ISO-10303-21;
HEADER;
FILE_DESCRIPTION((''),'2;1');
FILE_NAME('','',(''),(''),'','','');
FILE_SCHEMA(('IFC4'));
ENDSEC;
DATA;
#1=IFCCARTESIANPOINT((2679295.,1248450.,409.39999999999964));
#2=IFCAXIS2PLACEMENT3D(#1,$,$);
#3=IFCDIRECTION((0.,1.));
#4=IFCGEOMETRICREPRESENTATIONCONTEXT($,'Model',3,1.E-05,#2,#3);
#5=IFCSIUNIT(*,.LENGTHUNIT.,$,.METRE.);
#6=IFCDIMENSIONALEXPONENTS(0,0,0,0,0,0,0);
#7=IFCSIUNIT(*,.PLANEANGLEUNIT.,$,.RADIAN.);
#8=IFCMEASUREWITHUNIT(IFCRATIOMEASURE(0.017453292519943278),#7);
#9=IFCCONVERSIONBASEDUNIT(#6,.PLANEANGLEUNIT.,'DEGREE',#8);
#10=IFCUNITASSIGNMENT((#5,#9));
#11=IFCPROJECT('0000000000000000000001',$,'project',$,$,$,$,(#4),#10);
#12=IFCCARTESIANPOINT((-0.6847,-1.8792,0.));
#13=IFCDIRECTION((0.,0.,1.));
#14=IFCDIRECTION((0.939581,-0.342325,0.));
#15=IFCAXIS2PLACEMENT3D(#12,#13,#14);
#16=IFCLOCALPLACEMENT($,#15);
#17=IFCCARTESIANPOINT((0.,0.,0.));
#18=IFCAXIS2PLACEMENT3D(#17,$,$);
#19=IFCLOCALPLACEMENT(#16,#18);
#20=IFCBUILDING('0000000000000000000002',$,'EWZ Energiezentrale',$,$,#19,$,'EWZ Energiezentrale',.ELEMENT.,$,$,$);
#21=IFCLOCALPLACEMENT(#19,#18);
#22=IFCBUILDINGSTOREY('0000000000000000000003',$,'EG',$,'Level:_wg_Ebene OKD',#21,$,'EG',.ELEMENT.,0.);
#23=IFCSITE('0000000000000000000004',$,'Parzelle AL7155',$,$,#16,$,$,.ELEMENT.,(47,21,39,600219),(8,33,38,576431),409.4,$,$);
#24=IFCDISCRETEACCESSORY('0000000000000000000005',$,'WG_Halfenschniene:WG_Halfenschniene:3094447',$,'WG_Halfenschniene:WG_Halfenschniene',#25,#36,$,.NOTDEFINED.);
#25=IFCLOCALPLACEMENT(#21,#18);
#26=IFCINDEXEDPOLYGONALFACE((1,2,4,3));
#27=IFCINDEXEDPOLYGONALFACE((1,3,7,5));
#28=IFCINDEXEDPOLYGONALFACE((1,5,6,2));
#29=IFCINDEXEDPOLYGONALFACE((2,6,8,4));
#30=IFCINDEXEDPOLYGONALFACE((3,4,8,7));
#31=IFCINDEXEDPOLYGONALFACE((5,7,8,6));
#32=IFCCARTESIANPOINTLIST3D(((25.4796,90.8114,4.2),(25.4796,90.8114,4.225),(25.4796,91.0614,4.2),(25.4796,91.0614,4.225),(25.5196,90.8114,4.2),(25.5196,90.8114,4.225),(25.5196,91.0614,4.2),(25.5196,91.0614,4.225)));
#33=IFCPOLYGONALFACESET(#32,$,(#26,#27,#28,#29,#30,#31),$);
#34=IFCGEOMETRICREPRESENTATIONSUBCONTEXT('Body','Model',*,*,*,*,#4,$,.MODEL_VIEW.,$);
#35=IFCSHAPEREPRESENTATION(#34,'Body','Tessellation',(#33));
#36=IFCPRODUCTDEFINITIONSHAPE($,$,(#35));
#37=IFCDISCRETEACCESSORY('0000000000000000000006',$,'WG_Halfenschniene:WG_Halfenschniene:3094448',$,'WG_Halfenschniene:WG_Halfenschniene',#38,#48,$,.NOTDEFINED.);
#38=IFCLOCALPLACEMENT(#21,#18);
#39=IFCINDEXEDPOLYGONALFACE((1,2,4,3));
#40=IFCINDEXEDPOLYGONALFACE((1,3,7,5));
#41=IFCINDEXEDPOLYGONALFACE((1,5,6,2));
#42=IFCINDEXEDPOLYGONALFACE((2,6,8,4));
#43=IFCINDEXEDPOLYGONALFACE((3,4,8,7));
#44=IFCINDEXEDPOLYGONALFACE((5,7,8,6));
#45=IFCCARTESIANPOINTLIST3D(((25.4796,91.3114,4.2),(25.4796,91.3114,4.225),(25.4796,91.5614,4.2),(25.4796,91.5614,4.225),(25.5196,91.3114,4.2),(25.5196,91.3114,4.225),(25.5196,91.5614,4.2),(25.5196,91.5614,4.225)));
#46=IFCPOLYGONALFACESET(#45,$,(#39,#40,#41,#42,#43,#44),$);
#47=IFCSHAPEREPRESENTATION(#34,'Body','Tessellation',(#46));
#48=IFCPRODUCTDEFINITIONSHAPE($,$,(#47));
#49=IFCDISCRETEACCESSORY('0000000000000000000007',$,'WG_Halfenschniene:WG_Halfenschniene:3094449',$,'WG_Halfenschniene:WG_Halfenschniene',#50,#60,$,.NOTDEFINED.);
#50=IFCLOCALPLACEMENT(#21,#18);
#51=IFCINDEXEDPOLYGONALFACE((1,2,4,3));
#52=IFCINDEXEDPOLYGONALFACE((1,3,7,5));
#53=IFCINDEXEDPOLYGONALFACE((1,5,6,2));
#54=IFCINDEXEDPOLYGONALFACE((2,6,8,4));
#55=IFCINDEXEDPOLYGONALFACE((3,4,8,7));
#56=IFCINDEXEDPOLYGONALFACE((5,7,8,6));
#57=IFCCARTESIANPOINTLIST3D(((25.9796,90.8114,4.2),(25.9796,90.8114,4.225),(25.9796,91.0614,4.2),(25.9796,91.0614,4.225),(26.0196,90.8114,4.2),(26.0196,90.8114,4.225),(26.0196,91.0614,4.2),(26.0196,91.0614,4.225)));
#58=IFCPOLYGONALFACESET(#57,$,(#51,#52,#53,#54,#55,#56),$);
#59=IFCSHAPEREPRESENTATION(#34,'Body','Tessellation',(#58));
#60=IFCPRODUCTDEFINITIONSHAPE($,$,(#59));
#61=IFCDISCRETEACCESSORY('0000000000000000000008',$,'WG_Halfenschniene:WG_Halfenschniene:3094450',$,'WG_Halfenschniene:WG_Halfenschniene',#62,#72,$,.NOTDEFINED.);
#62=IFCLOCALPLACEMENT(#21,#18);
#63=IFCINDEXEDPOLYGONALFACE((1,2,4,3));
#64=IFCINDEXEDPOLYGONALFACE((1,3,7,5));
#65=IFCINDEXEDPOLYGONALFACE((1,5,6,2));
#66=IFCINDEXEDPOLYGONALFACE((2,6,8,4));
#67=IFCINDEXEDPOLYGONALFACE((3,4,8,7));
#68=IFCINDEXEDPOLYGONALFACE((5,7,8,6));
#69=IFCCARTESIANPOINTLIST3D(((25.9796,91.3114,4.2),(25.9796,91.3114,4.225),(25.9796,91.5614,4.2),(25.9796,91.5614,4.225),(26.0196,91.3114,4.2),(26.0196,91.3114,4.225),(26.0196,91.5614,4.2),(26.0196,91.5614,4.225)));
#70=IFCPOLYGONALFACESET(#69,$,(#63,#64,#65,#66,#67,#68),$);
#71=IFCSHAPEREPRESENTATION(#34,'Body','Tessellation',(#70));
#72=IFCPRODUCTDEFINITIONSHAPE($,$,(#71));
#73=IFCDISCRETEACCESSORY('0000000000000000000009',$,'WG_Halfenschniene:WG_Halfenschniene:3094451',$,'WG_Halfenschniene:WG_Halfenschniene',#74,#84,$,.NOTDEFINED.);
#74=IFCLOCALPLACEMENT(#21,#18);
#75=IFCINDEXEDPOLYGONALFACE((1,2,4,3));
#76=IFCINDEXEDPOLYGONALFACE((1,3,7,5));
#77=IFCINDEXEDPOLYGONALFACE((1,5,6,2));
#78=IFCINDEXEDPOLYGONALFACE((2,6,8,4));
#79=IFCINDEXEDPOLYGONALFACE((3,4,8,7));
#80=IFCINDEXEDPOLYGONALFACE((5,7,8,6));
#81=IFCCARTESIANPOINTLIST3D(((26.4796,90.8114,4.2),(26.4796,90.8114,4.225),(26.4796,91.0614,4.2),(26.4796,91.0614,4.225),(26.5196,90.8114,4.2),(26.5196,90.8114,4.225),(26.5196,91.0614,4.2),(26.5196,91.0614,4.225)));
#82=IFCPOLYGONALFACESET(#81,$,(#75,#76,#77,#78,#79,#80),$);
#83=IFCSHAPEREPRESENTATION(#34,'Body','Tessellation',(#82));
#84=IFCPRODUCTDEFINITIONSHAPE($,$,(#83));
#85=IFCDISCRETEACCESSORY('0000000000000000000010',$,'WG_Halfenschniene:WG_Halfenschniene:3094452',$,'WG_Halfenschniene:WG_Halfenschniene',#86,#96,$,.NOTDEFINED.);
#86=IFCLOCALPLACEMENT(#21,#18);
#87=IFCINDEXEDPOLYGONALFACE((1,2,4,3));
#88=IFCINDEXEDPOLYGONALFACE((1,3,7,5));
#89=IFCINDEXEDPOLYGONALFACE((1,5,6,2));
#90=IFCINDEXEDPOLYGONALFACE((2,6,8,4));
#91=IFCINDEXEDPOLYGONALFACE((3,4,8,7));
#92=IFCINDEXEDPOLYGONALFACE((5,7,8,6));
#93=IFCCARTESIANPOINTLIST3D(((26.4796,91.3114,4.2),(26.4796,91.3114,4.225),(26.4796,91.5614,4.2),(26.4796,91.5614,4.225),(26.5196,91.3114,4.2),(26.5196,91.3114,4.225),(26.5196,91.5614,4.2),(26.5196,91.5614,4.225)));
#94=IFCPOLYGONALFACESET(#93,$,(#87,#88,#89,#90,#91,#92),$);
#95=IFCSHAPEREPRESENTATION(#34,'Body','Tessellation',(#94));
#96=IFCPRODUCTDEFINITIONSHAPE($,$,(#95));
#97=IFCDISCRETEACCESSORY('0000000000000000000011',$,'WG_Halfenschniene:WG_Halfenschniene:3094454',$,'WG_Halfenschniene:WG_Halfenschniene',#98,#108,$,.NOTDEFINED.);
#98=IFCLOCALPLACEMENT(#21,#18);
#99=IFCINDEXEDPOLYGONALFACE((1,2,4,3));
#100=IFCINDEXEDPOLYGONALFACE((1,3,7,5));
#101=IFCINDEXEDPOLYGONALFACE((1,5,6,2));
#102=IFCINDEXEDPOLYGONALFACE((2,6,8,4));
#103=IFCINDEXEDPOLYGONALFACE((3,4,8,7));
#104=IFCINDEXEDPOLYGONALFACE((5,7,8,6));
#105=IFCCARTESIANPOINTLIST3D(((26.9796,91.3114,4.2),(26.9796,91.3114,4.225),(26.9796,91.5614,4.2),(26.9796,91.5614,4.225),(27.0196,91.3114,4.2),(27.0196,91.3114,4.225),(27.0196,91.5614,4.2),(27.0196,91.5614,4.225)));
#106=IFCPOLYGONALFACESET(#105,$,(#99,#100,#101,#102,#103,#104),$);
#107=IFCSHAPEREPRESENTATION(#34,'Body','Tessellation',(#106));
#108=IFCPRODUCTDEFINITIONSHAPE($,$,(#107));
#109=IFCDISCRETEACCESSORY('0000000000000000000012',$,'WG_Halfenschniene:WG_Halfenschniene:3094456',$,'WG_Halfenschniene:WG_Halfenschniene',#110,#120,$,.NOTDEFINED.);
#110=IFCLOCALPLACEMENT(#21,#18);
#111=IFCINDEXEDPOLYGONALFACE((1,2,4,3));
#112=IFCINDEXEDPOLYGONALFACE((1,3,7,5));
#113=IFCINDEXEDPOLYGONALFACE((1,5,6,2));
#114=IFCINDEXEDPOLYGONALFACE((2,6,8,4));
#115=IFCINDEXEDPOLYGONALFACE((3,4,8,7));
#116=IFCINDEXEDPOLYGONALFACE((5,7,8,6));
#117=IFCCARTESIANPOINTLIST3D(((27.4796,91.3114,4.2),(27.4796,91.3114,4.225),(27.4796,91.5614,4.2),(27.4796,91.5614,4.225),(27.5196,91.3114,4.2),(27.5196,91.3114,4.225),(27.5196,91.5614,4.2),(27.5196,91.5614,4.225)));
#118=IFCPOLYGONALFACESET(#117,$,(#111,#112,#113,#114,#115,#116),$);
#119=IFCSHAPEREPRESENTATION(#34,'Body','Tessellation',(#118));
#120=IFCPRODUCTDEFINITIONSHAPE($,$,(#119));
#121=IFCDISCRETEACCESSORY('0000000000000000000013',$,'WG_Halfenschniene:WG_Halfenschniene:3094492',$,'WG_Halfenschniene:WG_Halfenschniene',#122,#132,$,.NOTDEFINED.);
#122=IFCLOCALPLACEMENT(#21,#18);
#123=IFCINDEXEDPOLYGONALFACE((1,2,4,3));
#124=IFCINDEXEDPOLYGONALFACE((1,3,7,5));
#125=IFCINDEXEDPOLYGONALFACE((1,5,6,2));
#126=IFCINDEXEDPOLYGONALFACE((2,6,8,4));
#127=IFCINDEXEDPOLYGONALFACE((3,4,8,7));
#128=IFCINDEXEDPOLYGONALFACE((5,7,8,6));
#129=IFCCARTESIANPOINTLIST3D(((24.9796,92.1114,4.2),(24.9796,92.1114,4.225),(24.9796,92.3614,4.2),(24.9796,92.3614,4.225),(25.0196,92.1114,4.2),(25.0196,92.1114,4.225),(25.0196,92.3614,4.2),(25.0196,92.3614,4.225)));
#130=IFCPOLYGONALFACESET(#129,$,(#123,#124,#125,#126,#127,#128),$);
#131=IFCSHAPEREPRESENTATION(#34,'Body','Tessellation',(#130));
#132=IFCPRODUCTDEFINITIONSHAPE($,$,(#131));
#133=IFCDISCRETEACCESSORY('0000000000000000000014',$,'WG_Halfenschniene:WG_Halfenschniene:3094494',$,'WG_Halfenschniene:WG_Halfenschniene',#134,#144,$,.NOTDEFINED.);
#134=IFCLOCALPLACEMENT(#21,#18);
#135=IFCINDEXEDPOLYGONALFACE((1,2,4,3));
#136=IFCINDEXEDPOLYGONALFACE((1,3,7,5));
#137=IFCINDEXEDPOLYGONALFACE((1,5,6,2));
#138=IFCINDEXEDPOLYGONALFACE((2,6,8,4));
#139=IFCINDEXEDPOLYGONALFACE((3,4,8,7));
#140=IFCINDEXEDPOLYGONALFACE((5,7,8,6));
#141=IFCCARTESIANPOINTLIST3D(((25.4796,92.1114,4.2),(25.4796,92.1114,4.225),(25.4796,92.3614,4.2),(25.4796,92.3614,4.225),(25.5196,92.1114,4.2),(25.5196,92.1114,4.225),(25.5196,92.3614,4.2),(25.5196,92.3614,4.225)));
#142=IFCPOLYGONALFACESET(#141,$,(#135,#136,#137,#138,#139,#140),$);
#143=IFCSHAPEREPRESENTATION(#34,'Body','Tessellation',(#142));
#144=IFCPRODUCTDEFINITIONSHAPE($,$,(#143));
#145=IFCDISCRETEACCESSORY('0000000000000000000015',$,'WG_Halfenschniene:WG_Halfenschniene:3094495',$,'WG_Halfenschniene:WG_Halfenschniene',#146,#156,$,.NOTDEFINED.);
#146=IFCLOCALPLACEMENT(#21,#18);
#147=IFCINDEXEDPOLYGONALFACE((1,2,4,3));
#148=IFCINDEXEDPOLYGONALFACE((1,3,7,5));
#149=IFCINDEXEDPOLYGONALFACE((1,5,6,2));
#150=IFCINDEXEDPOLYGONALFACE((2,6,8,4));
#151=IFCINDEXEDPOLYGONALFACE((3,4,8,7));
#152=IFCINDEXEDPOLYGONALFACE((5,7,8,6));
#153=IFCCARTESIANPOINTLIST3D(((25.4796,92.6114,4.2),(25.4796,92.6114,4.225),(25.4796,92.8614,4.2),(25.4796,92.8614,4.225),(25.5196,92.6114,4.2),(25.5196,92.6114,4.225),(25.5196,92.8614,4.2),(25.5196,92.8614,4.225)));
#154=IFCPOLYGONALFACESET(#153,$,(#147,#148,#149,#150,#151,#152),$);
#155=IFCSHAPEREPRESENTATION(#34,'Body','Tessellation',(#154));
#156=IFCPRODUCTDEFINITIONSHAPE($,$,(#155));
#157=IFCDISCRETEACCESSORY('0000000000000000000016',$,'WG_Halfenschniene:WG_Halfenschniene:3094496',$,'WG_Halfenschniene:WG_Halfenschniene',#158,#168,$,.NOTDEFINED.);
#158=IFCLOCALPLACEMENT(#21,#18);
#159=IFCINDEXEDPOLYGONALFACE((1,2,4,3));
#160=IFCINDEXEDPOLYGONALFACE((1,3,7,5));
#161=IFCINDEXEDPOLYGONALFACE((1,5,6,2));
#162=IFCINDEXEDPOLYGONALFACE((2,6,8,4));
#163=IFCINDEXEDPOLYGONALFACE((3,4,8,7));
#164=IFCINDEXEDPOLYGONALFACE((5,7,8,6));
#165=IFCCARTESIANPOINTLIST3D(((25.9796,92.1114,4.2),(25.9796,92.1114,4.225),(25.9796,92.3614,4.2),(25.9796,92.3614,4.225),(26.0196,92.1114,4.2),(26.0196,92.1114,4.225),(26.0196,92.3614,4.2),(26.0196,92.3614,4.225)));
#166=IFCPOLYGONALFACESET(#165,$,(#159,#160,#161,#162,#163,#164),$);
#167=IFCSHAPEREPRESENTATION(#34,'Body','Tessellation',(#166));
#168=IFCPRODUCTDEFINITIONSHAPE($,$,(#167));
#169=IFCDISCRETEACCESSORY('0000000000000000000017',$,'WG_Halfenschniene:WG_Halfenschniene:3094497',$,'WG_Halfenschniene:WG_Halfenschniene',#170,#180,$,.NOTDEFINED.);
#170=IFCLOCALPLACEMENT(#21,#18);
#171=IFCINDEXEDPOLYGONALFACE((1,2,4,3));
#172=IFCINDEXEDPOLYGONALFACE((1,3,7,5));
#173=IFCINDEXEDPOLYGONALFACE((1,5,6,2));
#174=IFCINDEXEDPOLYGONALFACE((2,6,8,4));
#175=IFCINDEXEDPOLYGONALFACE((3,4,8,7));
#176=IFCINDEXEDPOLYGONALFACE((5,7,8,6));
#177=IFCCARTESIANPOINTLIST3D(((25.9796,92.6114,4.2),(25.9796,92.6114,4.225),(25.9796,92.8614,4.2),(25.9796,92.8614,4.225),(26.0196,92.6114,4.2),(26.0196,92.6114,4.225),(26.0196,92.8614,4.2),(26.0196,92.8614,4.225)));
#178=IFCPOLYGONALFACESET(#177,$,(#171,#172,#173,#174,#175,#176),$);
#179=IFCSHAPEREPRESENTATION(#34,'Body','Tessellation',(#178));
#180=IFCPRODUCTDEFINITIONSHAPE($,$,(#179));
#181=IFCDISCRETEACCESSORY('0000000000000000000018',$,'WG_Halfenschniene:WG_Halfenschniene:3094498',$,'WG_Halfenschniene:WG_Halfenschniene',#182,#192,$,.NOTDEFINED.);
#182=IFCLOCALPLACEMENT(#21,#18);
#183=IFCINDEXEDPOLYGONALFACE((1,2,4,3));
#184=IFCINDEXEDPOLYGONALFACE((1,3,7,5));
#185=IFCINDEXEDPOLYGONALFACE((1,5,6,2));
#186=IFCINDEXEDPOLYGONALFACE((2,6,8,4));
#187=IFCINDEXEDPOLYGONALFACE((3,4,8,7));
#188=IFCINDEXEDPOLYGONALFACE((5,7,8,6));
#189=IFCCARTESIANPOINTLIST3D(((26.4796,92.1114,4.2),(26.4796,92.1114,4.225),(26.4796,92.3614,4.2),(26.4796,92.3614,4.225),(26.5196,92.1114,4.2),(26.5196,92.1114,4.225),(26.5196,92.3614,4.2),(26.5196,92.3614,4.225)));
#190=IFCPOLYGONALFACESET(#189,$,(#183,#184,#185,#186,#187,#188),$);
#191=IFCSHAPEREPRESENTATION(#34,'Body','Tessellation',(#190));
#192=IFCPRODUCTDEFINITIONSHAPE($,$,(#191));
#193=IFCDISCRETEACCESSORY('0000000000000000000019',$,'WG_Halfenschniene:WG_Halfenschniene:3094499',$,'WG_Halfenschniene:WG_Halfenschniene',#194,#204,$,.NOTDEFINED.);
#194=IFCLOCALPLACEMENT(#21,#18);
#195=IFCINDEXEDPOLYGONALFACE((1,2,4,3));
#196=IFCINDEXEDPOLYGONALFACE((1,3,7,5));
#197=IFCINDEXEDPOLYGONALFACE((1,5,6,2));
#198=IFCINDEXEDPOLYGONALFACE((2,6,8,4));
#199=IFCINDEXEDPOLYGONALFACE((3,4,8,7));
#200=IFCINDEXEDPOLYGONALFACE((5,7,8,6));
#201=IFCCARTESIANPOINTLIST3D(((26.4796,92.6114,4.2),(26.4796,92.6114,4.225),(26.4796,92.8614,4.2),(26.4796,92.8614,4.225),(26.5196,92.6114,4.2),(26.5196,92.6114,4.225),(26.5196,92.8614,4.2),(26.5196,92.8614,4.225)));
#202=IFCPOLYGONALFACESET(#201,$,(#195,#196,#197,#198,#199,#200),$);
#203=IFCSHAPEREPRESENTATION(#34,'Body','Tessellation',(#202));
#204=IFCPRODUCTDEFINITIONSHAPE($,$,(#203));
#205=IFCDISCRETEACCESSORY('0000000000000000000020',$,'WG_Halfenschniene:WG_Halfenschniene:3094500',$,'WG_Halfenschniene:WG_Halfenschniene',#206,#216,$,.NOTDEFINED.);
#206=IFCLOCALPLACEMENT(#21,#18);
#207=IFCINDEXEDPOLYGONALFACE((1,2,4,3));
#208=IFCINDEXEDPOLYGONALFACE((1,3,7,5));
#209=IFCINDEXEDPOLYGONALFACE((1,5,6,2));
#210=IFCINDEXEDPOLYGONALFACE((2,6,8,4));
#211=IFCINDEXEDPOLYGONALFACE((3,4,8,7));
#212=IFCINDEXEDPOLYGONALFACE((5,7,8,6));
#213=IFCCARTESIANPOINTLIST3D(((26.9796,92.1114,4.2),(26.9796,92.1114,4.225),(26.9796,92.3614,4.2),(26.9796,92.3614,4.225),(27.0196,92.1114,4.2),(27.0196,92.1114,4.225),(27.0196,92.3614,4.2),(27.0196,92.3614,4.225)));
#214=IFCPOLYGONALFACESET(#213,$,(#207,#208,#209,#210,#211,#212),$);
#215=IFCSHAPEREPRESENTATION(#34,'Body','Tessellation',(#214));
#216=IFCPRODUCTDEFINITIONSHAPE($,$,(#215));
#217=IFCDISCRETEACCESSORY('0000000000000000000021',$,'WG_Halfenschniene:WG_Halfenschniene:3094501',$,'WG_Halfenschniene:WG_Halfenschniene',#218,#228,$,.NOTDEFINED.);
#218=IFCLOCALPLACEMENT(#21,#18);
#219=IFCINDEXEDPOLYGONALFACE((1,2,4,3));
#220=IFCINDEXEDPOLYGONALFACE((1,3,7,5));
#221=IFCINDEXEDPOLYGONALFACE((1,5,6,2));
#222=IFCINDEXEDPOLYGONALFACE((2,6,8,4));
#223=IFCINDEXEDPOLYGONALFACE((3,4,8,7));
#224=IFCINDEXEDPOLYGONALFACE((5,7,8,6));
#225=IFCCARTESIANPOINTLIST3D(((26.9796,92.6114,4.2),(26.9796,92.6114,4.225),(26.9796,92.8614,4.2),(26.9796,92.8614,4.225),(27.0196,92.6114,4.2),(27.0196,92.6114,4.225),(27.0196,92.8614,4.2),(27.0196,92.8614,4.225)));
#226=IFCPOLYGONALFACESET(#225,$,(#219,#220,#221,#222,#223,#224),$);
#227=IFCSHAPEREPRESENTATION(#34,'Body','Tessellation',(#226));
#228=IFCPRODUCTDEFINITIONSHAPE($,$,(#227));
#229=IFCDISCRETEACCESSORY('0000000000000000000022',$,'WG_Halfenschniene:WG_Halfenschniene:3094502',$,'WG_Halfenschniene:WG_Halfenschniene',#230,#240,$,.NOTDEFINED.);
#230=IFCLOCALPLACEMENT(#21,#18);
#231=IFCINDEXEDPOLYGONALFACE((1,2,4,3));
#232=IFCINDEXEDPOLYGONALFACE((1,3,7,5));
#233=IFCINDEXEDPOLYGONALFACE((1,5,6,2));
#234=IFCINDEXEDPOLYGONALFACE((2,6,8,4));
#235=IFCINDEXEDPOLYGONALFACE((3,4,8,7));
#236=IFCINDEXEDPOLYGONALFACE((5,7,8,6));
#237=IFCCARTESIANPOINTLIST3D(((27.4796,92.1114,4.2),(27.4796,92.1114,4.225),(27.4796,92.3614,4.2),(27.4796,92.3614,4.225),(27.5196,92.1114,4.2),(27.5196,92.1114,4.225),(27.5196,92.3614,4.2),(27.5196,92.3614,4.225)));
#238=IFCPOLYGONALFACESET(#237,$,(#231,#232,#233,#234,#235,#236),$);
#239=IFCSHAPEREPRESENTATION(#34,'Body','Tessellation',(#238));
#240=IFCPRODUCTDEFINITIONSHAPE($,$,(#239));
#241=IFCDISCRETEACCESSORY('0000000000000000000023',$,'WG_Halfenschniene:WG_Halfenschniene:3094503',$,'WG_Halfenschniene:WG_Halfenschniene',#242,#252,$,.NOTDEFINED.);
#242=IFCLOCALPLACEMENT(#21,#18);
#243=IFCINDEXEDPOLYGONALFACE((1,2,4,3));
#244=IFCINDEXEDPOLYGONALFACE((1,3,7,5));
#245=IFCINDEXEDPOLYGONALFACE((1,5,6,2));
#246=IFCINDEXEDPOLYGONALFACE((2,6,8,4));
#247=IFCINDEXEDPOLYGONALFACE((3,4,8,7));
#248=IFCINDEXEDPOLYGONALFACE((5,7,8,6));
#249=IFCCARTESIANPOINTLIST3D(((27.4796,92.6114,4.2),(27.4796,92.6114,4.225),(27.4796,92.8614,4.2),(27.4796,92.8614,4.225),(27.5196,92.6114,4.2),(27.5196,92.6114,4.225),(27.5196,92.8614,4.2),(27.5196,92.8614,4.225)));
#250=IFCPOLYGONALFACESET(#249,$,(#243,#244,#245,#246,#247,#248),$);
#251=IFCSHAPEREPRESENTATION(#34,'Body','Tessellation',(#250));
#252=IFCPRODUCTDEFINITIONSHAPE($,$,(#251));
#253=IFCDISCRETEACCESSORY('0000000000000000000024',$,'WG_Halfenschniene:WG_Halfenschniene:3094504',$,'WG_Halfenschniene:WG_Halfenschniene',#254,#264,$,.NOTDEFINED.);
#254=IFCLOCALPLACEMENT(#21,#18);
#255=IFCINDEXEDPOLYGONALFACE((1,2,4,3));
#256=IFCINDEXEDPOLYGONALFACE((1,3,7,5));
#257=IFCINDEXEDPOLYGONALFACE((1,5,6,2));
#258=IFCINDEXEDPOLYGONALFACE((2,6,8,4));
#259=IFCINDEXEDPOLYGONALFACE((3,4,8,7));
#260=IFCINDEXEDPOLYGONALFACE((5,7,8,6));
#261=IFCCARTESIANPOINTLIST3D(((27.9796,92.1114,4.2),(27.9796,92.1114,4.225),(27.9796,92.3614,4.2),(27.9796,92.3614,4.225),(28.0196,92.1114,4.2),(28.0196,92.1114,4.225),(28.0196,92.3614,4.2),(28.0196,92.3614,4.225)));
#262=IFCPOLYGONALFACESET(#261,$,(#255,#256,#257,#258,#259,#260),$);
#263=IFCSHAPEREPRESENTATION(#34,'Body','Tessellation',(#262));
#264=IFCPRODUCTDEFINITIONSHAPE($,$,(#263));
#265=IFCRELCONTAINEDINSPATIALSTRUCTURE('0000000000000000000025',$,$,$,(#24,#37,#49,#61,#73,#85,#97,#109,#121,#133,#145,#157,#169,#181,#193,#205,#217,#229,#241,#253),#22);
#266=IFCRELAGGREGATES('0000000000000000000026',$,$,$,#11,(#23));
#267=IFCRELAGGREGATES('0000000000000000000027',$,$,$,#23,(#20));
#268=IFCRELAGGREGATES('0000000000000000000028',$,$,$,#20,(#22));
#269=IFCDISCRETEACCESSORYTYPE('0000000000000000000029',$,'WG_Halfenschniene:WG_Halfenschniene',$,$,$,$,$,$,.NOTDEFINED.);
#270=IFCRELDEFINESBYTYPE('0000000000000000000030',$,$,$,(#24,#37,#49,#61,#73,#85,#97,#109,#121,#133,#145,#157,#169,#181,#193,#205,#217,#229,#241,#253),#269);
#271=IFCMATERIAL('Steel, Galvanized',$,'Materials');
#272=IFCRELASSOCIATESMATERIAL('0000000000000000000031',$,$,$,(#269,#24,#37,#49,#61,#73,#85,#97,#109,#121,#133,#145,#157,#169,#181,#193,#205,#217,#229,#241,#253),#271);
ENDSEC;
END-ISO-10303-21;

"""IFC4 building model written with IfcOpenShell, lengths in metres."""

from ifc_helpers import new_model, entity, si_unit, converted_unit, direction, frame, origin, place, context, subcontext, project, spatial, indexed_curve, outline, extrude, source, transform, mapped, material, type_object, element, save


model = new_model("IFC4")

# Units and contexts
model_context = context("Model", 3, precision=1e-05, world=frame((2679295.0, 1248450.0, 409.39999999999964)), true_north=direction((0.0, 1.0)))
body_context = subcontext(model_context, "Body", "Model", "MODEL_VIEW")
ifc_project = project(units=[si_unit("LENGTHUNIT", "METRE"), converted_unit("PLANEANGLEUNIT", "DEGREE", entity("IfcRatioMeasure", 0.017453292519943278), si_unit("PLANEANGLEUNIT", "RADIAN"), dimensions=[0, 0, 0, 0, 0, 0, 0])], contexts=[model_context])

# Site, building, storey
site_placement = place(None, frame((-0.6847, -1.8792, 0.0), z_axis=(0.0, 0.0, 1.0), x_axis=(0.939581, -0.342325, 0.0)))
site = spatial("IfcSite", under=ifc_project, at=site_placement, Name="Parzelle AL7155", CompositionType="ELEMENT", RefLatitude=(47, 21, 39, 600219), RefLongitude=(8, 33, 38, 576431), RefElevation=409.4)
building_placement = place(site_placement, origin())
building = spatial("IfcBuilding", under=site, at=building_placement, Name="EWZ Energiezentrale", LongName="EWZ Energiezentrale", CompositionType="ELEMENT")
storey_placement = place(building_placement, origin())
storey = spatial("IfcBuildingStorey", under=building, at=storey_placement, Name="EG", ObjectType="Level:_wg_Ebene OKD", LongName="EG", CompositionType="ELEMENT", Elevation=0.0)

# Discrete accessories
ifc_material = material(Name="Steel, Galvanized", Category="Materials")
discrete_accessory_type = type_object("IfcDiscreteAccessoryType", Name="WG_Halfenschniene:WG_Halfenschniene", PredefinedType="NOTDEFINED", material=ifc_material)
shared_shape = source(origin(), body_context, "Body", "SweptSolid", [
    extrude(outline(indexed_curve([(-0.125, -0.02), (0.125, -0.02), (0.125, 0.02), (-0.125, 0.02), (-0.125, -0.02)], self_intersect=False)), frame((0.125, 0.0, -0.0125)), (0.0, 0.0, 1.0), 0.025),
])
for number, where, z_axis, x_axis, name in (
    (1, (25.4996, 90.8114, 4.2125), (0.0, 0.0, -1.0), (0.0, 1.0, 0.0), "WG_Halfenschniene:WG_Halfenschniene:3094447"),
    (2, (25.4996, 91.3114, 4.2125), (0.0, 0.0, -1.0), (0.0, 1.0, 0.0), "WG_Halfenschniene:WG_Halfenschniene:3094448"),
    (3, (25.9996, 90.8114, 4.2125), (0.0, 0.0, -1.0), (0.0, 1.0, 0.0), "WG_Halfenschniene:WG_Halfenschniene:3094449"),
    (4, (25.9996, 91.3114, 4.2125), (0.0, 0.0, -1.0), (0.0, 1.0, 0.0), "WG_Halfenschniene:WG_Halfenschniene:3094450"),
    (5, (26.4996, 90.8114, 4.2125), (0.0, 0.0, -1.0), (0.0, 1.0, 0.0), "WG_Halfenschniene:WG_Halfenschniene:3094451"),
    (6, (26.4996, 91.3114, 4.2125), (0.0, 0.0, -1.0), (0.0, 1.0, 0.0), "WG_Halfenschniene:WG_Halfenschniene:3094452"),
    (7, (26.9996, 91.3114, 4.2125), (0.0, 0.0, -1.0), (0.0, 1.0, 0.0), "WG_Halfenschniene:WG_Halfenschniene:3094454"),
    (8, (27.4996, 91.3114, 4.2125), (0.0, 0.0, -1.0), (0.0, 1.0, 0.0), "WG_Halfenschniene:WG_Halfenschniene:3094456"),
    (9, (24.9996, 92.1114, 4.2125), (0.0, 0.0, -1.0), (0.0, 1.0, 0.0), "WG_Halfenschniene:WG_Halfenschniene:3094492"),
    (10, (25.4996, 92.1114, 4.2125), (0.0, 0.0, -1.0), (0.0, 1.0, 0.0), "WG_Halfenschniene:WG_Halfenschniene:3094494"),
    (11, (25.4996, 92.6114, 4.2125), (0.0, 0.0, -1.0), (0.0, 1.0, 0.0), "WG_Halfenschniene:WG_Halfenschniene:3094495"),
    (12, (25.9996, 92.1114, 4.2125), (0.0, 0.0, -1.0), (0.0, 1.0, 0.0), "WG_Halfenschniene:WG_Halfenschniene:3094496"),
    (13, (25.9996, 92.6114, 4.2125), (0.0, 0.0, -1.0), (0.0, 1.0, 0.0), "WG_Halfenschniene:WG_Halfenschniene:3094497"),
    (14, (26.4996, 92.1114, 4.2125), (0.0, 0.0, -1.0), (0.0, 1.0, 0.0), "WG_Halfenschniene:WG_Halfenschniene:3094498"),
    (15, (26.4996, 92.6114, 4.2125), (0.0, 0.0, -1.0), (0.0, 1.0, 0.0), "WG_Halfenschniene:WG_Halfenschniene:3094499"),
    (16, (26.9996, 92.1114, 4.2125), (0.0, 0.0, -1.0), (0.0, 1.0, 0.0), "WG_Halfenschniene:WG_Halfenschniene:3094500"),
    (17, (26.9996, 92.6114, 4.2125), (0.0, 0.0, -1.0), (0.0, 1.0, 0.0), "WG_Halfenschniene:WG_Halfenschniene:3094501"),
    (18, (27.4996, 92.1114, 4.2125), (0.0, 0.0, -1.0), (0.0, 1.0, 0.0), "WG_Halfenschniene:WG_Halfenschniene:3094502"),
    (19, (27.4996, 92.6114, 4.2125), (0.0, 0.0, -1.0), (0.0, 1.0, 0.0), "WG_Halfenschniene:WG_Halfenschniene:3094503"),
    (20, (27.9996, 92.1114, 4.2125), (0.0, 0.0, -1.0), (0.0, 1.0, 0.0), "WG_Halfenschniene:WG_Halfenschniene:3094504"),
):
    element("IfcDiscreteAccessory", number, at=place(storey_placement, frame(where, z_axis=z_axis, x_axis=x_axis)), inside=storey, type_object=discrete_accessory_type, material=ifc_material, Name=name, ObjectType="WG_Halfenschniene:WG_Halfenschniene", PredefinedType="NOTDEFINED", context=body_context, shape_type="MappedRepresentation", body=[
        mapped(shared_shape, transform((0.0, 0.0, 0.0), scale=1.0)),
    ])

save(model, "model.ifc")
